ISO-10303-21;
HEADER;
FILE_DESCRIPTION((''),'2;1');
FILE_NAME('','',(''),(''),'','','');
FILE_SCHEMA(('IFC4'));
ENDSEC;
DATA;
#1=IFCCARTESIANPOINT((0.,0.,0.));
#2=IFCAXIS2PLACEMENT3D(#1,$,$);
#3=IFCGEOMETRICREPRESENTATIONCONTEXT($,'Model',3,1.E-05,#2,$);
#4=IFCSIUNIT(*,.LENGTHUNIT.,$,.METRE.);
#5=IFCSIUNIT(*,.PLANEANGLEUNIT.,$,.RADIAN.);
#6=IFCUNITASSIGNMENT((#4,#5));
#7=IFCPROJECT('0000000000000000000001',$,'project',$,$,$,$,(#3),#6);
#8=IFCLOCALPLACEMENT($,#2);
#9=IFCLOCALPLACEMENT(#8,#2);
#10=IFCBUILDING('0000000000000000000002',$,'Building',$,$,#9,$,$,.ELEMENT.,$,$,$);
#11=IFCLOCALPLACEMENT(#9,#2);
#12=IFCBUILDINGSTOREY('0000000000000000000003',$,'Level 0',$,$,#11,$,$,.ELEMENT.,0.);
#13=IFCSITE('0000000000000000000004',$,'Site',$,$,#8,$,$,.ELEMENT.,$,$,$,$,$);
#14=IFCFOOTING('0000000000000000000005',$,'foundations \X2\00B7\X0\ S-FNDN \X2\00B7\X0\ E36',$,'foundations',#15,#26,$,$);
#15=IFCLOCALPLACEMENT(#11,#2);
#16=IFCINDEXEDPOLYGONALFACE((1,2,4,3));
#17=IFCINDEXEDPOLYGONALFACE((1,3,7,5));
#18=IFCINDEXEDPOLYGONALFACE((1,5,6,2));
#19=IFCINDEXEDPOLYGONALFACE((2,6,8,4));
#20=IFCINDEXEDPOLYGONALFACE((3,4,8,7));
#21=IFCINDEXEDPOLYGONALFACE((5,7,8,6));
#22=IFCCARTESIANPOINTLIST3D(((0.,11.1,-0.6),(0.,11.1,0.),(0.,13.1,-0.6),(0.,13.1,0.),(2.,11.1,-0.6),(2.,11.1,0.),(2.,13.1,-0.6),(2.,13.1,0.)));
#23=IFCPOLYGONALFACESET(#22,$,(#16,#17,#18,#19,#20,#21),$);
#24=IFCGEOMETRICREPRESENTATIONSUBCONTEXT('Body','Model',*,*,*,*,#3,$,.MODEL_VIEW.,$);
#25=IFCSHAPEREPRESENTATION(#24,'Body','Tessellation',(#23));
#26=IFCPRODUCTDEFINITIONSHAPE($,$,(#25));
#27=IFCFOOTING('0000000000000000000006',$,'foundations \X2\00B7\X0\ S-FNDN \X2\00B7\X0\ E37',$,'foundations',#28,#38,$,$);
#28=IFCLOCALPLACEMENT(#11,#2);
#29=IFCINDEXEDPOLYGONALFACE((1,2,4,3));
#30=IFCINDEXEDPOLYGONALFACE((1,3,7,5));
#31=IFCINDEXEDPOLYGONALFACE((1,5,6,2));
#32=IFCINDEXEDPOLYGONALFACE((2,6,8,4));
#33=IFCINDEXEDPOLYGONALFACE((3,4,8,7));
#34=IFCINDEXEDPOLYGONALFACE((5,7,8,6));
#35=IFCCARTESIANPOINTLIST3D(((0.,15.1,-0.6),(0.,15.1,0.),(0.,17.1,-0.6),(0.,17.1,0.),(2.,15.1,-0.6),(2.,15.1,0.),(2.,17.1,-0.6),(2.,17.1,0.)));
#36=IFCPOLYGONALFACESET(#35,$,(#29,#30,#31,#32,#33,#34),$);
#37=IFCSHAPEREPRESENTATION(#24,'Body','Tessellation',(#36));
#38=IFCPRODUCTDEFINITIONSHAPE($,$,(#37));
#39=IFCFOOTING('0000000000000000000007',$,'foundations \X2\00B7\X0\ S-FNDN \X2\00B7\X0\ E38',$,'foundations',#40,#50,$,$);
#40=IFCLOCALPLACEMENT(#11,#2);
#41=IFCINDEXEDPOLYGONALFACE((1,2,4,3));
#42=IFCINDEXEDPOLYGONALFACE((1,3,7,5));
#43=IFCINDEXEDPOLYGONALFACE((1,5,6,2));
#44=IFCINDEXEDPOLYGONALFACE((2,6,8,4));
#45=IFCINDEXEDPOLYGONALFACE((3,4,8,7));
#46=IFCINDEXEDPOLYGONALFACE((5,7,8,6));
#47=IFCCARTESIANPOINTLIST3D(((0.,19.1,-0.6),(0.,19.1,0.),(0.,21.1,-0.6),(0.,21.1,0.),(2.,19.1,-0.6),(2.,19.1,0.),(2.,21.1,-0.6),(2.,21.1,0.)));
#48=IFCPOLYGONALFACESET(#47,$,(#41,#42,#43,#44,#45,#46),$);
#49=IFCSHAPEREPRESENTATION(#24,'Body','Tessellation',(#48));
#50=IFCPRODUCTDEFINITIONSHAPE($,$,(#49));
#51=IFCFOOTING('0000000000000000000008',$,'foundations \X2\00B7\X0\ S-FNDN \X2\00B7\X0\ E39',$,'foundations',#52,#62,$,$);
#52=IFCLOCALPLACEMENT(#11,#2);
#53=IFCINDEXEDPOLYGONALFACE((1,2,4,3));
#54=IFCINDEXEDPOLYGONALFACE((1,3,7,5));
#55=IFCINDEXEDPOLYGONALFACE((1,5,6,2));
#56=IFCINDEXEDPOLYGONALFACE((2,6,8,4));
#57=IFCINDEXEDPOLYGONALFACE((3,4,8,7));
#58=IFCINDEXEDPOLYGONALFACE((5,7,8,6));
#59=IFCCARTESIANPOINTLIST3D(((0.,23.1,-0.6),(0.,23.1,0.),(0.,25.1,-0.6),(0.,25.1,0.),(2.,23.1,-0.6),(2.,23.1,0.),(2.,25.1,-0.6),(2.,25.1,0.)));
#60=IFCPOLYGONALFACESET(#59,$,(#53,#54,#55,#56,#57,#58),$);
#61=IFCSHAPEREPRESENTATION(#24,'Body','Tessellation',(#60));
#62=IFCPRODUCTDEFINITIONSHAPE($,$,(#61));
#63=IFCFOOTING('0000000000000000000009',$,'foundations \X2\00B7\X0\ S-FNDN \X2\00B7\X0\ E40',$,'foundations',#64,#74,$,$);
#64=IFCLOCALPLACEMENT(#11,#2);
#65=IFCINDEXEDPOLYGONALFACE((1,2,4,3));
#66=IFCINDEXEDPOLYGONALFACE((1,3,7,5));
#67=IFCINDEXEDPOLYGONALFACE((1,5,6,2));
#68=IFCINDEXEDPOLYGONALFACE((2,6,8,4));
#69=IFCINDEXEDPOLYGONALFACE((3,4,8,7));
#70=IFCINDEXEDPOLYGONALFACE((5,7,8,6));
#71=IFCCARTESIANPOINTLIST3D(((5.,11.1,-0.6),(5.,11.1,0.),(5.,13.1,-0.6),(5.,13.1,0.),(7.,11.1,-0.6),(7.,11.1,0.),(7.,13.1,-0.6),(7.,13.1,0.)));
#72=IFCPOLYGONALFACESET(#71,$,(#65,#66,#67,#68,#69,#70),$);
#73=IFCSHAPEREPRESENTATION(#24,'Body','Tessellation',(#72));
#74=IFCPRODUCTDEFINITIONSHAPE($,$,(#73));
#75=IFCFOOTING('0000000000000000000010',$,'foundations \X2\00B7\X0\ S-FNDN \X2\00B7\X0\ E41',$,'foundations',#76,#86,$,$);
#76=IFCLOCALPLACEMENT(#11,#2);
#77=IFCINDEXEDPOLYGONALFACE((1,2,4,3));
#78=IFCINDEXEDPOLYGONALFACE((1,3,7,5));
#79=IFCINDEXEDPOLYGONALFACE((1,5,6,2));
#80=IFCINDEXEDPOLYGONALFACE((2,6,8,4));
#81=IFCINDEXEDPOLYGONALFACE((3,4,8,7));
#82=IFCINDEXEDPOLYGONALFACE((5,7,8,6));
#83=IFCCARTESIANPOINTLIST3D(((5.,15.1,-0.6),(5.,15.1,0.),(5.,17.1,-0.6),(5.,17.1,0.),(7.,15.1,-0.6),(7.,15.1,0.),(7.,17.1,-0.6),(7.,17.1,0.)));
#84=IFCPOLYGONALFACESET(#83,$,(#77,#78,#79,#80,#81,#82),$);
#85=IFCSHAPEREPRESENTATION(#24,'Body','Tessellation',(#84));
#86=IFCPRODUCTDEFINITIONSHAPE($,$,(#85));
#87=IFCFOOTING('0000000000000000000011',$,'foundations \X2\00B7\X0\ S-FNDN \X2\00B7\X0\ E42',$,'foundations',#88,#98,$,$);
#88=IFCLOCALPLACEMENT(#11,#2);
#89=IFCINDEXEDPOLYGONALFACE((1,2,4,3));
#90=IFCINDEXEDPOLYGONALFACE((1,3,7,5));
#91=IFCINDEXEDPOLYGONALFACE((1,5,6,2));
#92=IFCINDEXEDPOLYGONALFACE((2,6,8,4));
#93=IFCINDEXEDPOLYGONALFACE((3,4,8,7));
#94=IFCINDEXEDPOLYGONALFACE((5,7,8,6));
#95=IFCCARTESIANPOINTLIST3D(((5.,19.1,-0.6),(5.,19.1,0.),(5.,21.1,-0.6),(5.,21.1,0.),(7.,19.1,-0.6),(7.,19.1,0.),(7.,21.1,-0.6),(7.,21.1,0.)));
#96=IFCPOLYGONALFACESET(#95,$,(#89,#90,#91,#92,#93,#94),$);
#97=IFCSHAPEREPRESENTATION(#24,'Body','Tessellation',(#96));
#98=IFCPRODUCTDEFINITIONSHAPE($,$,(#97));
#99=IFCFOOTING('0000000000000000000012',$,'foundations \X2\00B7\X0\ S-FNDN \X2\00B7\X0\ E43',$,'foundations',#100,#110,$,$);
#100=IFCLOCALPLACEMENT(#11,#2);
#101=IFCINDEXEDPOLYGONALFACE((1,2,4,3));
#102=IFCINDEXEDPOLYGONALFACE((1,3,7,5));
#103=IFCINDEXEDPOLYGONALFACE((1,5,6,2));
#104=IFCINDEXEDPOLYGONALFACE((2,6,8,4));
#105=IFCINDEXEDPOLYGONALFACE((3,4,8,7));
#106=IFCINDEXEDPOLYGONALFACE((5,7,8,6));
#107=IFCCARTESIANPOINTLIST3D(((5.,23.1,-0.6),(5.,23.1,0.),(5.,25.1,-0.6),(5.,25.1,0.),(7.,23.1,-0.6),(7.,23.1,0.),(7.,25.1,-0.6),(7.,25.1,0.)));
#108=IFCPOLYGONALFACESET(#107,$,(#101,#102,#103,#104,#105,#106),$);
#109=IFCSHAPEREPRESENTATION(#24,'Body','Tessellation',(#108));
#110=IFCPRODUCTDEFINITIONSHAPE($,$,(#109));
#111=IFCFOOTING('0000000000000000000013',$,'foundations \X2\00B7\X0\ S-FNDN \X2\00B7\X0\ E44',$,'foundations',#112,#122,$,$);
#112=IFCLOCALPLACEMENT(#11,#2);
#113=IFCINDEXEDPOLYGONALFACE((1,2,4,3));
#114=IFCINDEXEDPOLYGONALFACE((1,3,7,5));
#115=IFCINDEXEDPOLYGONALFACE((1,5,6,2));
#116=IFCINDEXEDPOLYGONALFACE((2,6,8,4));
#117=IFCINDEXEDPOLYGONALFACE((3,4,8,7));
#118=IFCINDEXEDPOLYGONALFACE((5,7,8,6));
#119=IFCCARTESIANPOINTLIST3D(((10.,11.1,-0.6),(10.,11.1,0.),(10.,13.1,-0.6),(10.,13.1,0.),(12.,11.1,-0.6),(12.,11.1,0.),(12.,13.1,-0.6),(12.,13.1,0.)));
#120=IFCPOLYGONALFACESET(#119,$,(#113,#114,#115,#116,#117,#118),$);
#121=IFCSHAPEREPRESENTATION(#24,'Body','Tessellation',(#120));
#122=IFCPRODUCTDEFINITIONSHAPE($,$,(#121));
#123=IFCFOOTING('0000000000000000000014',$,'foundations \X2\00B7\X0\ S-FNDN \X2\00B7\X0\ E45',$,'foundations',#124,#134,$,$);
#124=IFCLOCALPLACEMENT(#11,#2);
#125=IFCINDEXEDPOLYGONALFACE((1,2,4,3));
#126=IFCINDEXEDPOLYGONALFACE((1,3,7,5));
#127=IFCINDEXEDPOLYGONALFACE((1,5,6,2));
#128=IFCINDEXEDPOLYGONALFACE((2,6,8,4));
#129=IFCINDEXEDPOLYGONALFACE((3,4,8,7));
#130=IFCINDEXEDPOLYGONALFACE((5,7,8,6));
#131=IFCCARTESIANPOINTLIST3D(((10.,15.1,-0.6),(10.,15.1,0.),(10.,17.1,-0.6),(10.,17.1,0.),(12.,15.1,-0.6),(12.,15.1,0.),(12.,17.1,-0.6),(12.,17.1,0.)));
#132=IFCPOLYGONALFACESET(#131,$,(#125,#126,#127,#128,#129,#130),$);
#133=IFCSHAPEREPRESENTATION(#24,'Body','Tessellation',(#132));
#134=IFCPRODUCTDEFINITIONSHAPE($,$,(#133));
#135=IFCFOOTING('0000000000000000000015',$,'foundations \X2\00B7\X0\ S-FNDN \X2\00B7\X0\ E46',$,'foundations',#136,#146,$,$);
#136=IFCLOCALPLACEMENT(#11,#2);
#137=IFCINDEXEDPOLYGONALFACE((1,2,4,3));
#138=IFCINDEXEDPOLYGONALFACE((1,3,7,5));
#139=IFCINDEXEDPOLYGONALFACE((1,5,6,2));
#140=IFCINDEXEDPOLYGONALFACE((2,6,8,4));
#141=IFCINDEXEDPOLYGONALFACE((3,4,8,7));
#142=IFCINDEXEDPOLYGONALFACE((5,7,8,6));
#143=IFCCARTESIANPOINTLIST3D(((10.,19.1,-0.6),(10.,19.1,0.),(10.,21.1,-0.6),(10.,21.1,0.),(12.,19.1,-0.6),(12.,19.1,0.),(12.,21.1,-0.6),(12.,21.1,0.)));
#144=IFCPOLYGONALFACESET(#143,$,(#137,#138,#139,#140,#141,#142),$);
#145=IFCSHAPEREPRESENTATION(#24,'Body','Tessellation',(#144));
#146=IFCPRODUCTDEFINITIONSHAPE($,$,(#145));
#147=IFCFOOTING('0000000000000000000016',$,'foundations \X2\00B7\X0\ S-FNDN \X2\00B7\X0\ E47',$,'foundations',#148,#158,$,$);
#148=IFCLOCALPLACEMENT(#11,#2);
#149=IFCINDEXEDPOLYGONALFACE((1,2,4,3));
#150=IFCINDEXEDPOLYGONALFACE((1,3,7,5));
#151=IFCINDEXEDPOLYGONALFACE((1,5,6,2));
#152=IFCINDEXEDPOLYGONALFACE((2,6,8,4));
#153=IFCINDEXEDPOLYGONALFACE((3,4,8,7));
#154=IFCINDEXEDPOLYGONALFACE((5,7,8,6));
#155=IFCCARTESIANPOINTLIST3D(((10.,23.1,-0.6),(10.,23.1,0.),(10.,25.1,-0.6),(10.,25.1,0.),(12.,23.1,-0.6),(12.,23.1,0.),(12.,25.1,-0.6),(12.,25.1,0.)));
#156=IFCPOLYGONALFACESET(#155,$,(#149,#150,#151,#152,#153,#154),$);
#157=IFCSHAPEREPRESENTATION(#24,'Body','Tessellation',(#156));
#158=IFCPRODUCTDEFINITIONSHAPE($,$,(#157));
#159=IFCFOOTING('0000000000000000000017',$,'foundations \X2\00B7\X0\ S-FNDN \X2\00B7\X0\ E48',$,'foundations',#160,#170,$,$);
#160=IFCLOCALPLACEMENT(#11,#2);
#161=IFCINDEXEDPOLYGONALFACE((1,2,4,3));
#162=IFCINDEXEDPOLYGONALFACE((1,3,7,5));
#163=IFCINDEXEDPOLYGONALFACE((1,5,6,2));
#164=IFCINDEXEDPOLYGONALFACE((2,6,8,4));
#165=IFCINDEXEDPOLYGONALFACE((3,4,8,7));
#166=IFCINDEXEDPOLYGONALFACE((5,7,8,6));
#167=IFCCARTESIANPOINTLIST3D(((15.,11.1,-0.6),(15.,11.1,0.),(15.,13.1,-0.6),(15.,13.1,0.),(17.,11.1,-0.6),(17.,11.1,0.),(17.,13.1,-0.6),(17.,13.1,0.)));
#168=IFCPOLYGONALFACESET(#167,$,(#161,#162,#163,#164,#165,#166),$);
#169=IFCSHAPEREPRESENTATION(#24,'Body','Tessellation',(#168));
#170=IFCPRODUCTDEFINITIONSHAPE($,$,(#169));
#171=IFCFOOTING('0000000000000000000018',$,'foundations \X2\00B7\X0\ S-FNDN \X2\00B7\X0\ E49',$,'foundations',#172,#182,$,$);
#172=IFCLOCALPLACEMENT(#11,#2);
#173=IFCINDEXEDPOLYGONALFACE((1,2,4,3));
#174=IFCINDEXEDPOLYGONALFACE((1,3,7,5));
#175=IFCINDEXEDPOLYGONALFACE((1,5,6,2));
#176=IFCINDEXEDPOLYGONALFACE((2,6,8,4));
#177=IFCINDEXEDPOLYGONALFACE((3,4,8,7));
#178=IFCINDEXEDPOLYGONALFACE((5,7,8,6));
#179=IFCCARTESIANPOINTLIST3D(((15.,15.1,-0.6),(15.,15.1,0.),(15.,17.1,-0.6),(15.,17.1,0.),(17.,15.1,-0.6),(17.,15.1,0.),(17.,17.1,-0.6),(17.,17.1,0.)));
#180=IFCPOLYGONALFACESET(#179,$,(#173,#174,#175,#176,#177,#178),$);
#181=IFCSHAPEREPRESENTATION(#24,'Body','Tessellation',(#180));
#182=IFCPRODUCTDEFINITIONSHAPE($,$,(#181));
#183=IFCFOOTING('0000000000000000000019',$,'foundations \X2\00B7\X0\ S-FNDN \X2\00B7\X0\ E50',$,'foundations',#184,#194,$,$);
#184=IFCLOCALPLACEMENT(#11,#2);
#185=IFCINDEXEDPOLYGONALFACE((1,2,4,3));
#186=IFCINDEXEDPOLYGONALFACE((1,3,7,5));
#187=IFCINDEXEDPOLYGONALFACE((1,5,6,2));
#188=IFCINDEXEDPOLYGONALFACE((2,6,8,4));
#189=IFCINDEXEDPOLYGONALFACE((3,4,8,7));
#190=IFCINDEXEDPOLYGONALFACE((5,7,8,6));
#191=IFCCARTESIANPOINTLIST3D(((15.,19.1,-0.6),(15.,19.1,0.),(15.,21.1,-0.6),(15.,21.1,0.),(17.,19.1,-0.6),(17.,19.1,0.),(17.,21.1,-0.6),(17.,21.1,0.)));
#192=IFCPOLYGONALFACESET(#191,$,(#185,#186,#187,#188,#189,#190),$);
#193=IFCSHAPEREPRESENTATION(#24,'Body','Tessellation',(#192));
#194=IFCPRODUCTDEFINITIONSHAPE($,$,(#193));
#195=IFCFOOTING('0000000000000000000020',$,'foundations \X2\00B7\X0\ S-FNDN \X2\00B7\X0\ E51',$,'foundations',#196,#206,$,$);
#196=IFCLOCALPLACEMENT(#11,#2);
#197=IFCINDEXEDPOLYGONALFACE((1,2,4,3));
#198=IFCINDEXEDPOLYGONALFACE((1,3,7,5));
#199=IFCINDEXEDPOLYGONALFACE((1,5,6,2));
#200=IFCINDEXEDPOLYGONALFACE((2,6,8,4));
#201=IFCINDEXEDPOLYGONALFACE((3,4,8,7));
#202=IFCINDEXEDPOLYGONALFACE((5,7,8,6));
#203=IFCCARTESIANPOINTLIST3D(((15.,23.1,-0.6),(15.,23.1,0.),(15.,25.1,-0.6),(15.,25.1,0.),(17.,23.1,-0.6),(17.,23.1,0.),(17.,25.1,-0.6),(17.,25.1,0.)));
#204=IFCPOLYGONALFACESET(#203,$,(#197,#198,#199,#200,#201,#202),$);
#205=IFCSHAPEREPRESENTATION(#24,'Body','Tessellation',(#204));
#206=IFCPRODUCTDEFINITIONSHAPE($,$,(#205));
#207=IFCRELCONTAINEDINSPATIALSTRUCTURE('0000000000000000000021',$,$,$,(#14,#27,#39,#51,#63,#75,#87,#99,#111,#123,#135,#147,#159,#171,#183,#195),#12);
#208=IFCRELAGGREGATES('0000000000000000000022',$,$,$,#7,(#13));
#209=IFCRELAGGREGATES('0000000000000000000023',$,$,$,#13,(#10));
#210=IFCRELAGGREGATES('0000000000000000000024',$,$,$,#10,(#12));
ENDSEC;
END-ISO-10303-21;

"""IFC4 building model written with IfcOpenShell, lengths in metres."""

from ifc_helpers import new_model, si_unit, frame, origin, place, context, subcontext, project, spatial, polyline, outline, extrude, element, save


model = new_model("IFC4")

# Units and contexts
model_context = context("Model", 3, precision=1e-05, world=origin())
body_context = subcontext(model_context, "Body", "Model", "MODEL_VIEW")
ifc_project = project(units=[si_unit("LENGTHUNIT", "METRE"), si_unit("PLANEANGLEUNIT", "RADIAN")], contexts=[model_context])

# Site, building, storey
site_placement = place(None, origin())
site = spatial("IfcSite", under=ifc_project, at=site_placement, Name="Site", CompositionType="ELEMENT")
building_placement = place(site_placement, origin())
building = spatial("IfcBuilding", under=site, at=building_placement, Name="Building", CompositionType="ELEMENT")
storey_placement = place(building_placement, origin())
storey = spatial("IfcBuildingStorey", under=building, at=storey_placement, Name="Level 0", CompositionType="ELEMENT", Elevation=0.0)

# Footings
footing_1_placement = place(storey_placement, frame((0.0, 0.0, -0.6)))
element("IfcFooting", 1, at=footing_1_placement, inside=storey, Name="foundations · S-FNDN · E36", ObjectType="foundations", context=body_context, shape_type="SweptSolid", body=[
    extrude(outline(polyline([(0.0, 11.1), (2.0, 11.1), (2.0, 13.1), (0.0, 13.1), (0.0, 11.1)])), origin(), (0.0, 0.0, 1.0), 0.6),
])
footing_2_placement = place(storey_placement, frame((0.0, 0.0, -0.6)))
element("IfcFooting", 2, at=footing_2_placement, inside=storey, Name="foundations · S-FNDN · E37", ObjectType="foundations", context=body_context, shape_type="SweptSolid", body=[
    extrude(outline(polyline([(0.0, 15.1), (2.0, 15.1), (2.0, 17.1), (0.0, 17.1), (0.0, 15.1)])), origin(), (0.0, 0.0, 1.0), 0.6),
])
footing_3_placement = place(storey_placement, frame((0.0, 0.0, -0.6)))
element("IfcFooting", 3, at=footing_3_placement, inside=storey, Name="foundations · S-FNDN · E38", ObjectType="foundations", context=body_context, shape_type="SweptSolid", body=[
    extrude(outline(polyline([(0.0, 19.1), (2.0, 19.1), (2.0, 21.1), (0.0, 21.1), (0.0, 19.1)])), origin(), (0.0, 0.0, 1.0), 0.6),
])
footing_4_placement = place(storey_placement, frame((0.0, 0.0, -0.6)))
element("IfcFooting", 4, at=footing_4_placement, inside=storey, Name="foundations · S-FNDN · E39", ObjectType="foundations", context=body_context, shape_type="SweptSolid", body=[
    extrude(outline(polyline([(0.0, 23.1), (2.0, 23.1), (2.0, 25.1), (0.0, 25.1), (0.0, 23.1)])), origin(), (0.0, 0.0, 1.0), 0.6),
])
footing_5_placement = place(storey_placement, frame((0.0, 0.0, -0.6)))
element("IfcFooting", 5, at=footing_5_placement, inside=storey, Name="foundations · S-FNDN · E40", ObjectType="foundations", context=body_context, shape_type="SweptSolid", body=[
    extrude(outline(polyline([(5.0, 11.1), (7.0, 11.1), (7.0, 13.1), (5.0, 13.1), (5.0, 11.1)])), origin(), (0.0, 0.0, 1.0), 0.6),
])
footing_6_placement = place(storey_placement, frame((0.0, 0.0, -0.6)))
element("IfcFooting", 6, at=footing_6_placement, inside=storey, Name="foundations · S-FNDN · E41", ObjectType="foundations", context=body_context, shape_type="SweptSolid", body=[
    extrude(outline(polyline([(5.0, 15.1), (7.0, 15.1), (7.0, 17.1), (5.0, 17.1), (5.0, 15.1)])), origin(), (0.0, 0.0, 1.0), 0.6),
])
footing_7_placement = place(storey_placement, frame((0.0, 0.0, -0.6)))
element("IfcFooting", 7, at=footing_7_placement, inside=storey, Name="foundations · S-FNDN · E42", ObjectType="foundations", context=body_context, shape_type="SweptSolid", body=[
    extrude(outline(polyline([(5.0, 19.1), (7.0, 19.1), (7.0, 21.1), (5.0, 21.1), (5.0, 19.1)])), origin(), (0.0, 0.0, 1.0), 0.6),
])
footing_8_placement = place(storey_placement, frame((0.0, 0.0, -0.6)))
element("IfcFooting", 8, at=footing_8_placement, inside=storey, Name="foundations · S-FNDN · E43", ObjectType="foundations", context=body_context, shape_type="SweptSolid", body=[
    extrude(outline(polyline([(5.0, 23.1), (7.0, 23.1), (7.0, 25.1), (5.0, 25.1), (5.0, 23.1)])), origin(), (0.0, 0.0, 1.0), 0.6),
])
footing_9_placement = place(storey_placement, frame((0.0, 0.0, -0.6)))
element("IfcFooting", 9, at=footing_9_placement, inside=storey, Name="foundations · S-FNDN · E44", ObjectType="foundations", context=body_context, shape_type="SweptSolid", body=[
    extrude(outline(polyline([(10.0, 11.1), (12.0, 11.1), (12.0, 13.1), (10.0, 13.1), (10.0, 11.1)])), origin(), (0.0, 0.0, 1.0), 0.6),
])
footing_10_placement = place(storey_placement, frame((0.0, 0.0, -0.6)))
element("IfcFooting", 10, at=footing_10_placement, inside=storey, Name="foundations · S-FNDN · E45", ObjectType="foundations", context=body_context, shape_type="SweptSolid", body=[
    extrude(outline(polyline([(10.0, 15.1), (12.0, 15.1), (12.0, 17.1), (10.0, 17.1), (10.0, 15.1)])), origin(), (0.0, 0.0, 1.0), 0.6),
])
footing_11_placement = place(storey_placement, frame((0.0, 0.0, -0.6)))
element("IfcFooting", 11, at=footing_11_placement, inside=storey, Name="foundations · S-FNDN · E46", ObjectType="foundations", context=body_context, shape_type="SweptSolid", body=[
    extrude(outline(polyline([(10.0, 19.1), (12.0, 19.1), (12.0, 21.1), (10.0, 21.1), (10.0, 19.1)])), origin(), (0.0, 0.0, 1.0), 0.6),
])
footing_12_placement = place(storey_placement, frame((0.0, 0.0, -0.6)))
element("IfcFooting", 12, at=footing_12_placement, inside=storey, Name="foundations · S-FNDN · E47", ObjectType="foundations", context=body_context, shape_type="SweptSolid", body=[
    extrude(outline(polyline([(10.0, 23.1), (12.0, 23.1), (12.0, 25.1), (10.0, 25.1), (10.0, 23.1)])), origin(), (0.0, 0.0, 1.0), 0.6),
])
footing_13_placement = place(storey_placement, frame((0.0, 0.0, -0.6)))
element("IfcFooting", 13, at=footing_13_placement, inside=storey, Name="foundations · S-FNDN · E48", ObjectType="foundations", context=body_context, shape_type="SweptSolid", body=[
    extrude(outline(polyline([(15.0, 11.1), (17.0, 11.1), (17.0, 13.1), (15.0, 13.1), (15.0, 11.1)])), origin(), (0.0, 0.0, 1.0), 0.6),
])
footing_14_placement = place(storey_placement, frame((0.0, 0.0, -0.6)))
element("IfcFooting", 14, at=footing_14_placement, inside=storey, Name="foundations · S-FNDN · E49", ObjectType="foundations", context=body_context, shape_type="SweptSolid", body=[
    extrude(outline(polyline([(15.0, 15.1), (17.0, 15.1), (17.0, 17.1), (15.0, 17.1), (15.0, 15.1)])), origin(), (0.0, 0.0, 1.0), 0.6),
])
footing_15_placement = place(storey_placement, frame((0.0, 0.0, -0.6)))
element("IfcFooting", 15, at=footing_15_placement, inside=storey, Name="foundations · S-FNDN · E50", ObjectType="foundations", context=body_context, shape_type="SweptSolid", body=[
    extrude(outline(polyline([(15.0, 19.1), (17.0, 19.1), (17.0, 21.1), (15.0, 21.1), (15.0, 19.1)])), origin(), (0.0, 0.0, 1.0), 0.6),
])
footing_16_placement = place(storey_placement, frame((0.0, 0.0, -0.6)))
element("IfcFooting", 16, at=footing_16_placement, inside=storey, Name="foundations · S-FNDN · E51", ObjectType="foundations", context=body_context, shape_type="SweptSolid", body=[
    extrude(outline(polyline([(15.0, 23.1), (17.0, 23.1), (17.0, 25.1), (15.0, 25.1), (15.0, 23.1)])), origin(), (0.0, 0.0, 1.0), 0.6),
])

save(model, "model.ifc")
